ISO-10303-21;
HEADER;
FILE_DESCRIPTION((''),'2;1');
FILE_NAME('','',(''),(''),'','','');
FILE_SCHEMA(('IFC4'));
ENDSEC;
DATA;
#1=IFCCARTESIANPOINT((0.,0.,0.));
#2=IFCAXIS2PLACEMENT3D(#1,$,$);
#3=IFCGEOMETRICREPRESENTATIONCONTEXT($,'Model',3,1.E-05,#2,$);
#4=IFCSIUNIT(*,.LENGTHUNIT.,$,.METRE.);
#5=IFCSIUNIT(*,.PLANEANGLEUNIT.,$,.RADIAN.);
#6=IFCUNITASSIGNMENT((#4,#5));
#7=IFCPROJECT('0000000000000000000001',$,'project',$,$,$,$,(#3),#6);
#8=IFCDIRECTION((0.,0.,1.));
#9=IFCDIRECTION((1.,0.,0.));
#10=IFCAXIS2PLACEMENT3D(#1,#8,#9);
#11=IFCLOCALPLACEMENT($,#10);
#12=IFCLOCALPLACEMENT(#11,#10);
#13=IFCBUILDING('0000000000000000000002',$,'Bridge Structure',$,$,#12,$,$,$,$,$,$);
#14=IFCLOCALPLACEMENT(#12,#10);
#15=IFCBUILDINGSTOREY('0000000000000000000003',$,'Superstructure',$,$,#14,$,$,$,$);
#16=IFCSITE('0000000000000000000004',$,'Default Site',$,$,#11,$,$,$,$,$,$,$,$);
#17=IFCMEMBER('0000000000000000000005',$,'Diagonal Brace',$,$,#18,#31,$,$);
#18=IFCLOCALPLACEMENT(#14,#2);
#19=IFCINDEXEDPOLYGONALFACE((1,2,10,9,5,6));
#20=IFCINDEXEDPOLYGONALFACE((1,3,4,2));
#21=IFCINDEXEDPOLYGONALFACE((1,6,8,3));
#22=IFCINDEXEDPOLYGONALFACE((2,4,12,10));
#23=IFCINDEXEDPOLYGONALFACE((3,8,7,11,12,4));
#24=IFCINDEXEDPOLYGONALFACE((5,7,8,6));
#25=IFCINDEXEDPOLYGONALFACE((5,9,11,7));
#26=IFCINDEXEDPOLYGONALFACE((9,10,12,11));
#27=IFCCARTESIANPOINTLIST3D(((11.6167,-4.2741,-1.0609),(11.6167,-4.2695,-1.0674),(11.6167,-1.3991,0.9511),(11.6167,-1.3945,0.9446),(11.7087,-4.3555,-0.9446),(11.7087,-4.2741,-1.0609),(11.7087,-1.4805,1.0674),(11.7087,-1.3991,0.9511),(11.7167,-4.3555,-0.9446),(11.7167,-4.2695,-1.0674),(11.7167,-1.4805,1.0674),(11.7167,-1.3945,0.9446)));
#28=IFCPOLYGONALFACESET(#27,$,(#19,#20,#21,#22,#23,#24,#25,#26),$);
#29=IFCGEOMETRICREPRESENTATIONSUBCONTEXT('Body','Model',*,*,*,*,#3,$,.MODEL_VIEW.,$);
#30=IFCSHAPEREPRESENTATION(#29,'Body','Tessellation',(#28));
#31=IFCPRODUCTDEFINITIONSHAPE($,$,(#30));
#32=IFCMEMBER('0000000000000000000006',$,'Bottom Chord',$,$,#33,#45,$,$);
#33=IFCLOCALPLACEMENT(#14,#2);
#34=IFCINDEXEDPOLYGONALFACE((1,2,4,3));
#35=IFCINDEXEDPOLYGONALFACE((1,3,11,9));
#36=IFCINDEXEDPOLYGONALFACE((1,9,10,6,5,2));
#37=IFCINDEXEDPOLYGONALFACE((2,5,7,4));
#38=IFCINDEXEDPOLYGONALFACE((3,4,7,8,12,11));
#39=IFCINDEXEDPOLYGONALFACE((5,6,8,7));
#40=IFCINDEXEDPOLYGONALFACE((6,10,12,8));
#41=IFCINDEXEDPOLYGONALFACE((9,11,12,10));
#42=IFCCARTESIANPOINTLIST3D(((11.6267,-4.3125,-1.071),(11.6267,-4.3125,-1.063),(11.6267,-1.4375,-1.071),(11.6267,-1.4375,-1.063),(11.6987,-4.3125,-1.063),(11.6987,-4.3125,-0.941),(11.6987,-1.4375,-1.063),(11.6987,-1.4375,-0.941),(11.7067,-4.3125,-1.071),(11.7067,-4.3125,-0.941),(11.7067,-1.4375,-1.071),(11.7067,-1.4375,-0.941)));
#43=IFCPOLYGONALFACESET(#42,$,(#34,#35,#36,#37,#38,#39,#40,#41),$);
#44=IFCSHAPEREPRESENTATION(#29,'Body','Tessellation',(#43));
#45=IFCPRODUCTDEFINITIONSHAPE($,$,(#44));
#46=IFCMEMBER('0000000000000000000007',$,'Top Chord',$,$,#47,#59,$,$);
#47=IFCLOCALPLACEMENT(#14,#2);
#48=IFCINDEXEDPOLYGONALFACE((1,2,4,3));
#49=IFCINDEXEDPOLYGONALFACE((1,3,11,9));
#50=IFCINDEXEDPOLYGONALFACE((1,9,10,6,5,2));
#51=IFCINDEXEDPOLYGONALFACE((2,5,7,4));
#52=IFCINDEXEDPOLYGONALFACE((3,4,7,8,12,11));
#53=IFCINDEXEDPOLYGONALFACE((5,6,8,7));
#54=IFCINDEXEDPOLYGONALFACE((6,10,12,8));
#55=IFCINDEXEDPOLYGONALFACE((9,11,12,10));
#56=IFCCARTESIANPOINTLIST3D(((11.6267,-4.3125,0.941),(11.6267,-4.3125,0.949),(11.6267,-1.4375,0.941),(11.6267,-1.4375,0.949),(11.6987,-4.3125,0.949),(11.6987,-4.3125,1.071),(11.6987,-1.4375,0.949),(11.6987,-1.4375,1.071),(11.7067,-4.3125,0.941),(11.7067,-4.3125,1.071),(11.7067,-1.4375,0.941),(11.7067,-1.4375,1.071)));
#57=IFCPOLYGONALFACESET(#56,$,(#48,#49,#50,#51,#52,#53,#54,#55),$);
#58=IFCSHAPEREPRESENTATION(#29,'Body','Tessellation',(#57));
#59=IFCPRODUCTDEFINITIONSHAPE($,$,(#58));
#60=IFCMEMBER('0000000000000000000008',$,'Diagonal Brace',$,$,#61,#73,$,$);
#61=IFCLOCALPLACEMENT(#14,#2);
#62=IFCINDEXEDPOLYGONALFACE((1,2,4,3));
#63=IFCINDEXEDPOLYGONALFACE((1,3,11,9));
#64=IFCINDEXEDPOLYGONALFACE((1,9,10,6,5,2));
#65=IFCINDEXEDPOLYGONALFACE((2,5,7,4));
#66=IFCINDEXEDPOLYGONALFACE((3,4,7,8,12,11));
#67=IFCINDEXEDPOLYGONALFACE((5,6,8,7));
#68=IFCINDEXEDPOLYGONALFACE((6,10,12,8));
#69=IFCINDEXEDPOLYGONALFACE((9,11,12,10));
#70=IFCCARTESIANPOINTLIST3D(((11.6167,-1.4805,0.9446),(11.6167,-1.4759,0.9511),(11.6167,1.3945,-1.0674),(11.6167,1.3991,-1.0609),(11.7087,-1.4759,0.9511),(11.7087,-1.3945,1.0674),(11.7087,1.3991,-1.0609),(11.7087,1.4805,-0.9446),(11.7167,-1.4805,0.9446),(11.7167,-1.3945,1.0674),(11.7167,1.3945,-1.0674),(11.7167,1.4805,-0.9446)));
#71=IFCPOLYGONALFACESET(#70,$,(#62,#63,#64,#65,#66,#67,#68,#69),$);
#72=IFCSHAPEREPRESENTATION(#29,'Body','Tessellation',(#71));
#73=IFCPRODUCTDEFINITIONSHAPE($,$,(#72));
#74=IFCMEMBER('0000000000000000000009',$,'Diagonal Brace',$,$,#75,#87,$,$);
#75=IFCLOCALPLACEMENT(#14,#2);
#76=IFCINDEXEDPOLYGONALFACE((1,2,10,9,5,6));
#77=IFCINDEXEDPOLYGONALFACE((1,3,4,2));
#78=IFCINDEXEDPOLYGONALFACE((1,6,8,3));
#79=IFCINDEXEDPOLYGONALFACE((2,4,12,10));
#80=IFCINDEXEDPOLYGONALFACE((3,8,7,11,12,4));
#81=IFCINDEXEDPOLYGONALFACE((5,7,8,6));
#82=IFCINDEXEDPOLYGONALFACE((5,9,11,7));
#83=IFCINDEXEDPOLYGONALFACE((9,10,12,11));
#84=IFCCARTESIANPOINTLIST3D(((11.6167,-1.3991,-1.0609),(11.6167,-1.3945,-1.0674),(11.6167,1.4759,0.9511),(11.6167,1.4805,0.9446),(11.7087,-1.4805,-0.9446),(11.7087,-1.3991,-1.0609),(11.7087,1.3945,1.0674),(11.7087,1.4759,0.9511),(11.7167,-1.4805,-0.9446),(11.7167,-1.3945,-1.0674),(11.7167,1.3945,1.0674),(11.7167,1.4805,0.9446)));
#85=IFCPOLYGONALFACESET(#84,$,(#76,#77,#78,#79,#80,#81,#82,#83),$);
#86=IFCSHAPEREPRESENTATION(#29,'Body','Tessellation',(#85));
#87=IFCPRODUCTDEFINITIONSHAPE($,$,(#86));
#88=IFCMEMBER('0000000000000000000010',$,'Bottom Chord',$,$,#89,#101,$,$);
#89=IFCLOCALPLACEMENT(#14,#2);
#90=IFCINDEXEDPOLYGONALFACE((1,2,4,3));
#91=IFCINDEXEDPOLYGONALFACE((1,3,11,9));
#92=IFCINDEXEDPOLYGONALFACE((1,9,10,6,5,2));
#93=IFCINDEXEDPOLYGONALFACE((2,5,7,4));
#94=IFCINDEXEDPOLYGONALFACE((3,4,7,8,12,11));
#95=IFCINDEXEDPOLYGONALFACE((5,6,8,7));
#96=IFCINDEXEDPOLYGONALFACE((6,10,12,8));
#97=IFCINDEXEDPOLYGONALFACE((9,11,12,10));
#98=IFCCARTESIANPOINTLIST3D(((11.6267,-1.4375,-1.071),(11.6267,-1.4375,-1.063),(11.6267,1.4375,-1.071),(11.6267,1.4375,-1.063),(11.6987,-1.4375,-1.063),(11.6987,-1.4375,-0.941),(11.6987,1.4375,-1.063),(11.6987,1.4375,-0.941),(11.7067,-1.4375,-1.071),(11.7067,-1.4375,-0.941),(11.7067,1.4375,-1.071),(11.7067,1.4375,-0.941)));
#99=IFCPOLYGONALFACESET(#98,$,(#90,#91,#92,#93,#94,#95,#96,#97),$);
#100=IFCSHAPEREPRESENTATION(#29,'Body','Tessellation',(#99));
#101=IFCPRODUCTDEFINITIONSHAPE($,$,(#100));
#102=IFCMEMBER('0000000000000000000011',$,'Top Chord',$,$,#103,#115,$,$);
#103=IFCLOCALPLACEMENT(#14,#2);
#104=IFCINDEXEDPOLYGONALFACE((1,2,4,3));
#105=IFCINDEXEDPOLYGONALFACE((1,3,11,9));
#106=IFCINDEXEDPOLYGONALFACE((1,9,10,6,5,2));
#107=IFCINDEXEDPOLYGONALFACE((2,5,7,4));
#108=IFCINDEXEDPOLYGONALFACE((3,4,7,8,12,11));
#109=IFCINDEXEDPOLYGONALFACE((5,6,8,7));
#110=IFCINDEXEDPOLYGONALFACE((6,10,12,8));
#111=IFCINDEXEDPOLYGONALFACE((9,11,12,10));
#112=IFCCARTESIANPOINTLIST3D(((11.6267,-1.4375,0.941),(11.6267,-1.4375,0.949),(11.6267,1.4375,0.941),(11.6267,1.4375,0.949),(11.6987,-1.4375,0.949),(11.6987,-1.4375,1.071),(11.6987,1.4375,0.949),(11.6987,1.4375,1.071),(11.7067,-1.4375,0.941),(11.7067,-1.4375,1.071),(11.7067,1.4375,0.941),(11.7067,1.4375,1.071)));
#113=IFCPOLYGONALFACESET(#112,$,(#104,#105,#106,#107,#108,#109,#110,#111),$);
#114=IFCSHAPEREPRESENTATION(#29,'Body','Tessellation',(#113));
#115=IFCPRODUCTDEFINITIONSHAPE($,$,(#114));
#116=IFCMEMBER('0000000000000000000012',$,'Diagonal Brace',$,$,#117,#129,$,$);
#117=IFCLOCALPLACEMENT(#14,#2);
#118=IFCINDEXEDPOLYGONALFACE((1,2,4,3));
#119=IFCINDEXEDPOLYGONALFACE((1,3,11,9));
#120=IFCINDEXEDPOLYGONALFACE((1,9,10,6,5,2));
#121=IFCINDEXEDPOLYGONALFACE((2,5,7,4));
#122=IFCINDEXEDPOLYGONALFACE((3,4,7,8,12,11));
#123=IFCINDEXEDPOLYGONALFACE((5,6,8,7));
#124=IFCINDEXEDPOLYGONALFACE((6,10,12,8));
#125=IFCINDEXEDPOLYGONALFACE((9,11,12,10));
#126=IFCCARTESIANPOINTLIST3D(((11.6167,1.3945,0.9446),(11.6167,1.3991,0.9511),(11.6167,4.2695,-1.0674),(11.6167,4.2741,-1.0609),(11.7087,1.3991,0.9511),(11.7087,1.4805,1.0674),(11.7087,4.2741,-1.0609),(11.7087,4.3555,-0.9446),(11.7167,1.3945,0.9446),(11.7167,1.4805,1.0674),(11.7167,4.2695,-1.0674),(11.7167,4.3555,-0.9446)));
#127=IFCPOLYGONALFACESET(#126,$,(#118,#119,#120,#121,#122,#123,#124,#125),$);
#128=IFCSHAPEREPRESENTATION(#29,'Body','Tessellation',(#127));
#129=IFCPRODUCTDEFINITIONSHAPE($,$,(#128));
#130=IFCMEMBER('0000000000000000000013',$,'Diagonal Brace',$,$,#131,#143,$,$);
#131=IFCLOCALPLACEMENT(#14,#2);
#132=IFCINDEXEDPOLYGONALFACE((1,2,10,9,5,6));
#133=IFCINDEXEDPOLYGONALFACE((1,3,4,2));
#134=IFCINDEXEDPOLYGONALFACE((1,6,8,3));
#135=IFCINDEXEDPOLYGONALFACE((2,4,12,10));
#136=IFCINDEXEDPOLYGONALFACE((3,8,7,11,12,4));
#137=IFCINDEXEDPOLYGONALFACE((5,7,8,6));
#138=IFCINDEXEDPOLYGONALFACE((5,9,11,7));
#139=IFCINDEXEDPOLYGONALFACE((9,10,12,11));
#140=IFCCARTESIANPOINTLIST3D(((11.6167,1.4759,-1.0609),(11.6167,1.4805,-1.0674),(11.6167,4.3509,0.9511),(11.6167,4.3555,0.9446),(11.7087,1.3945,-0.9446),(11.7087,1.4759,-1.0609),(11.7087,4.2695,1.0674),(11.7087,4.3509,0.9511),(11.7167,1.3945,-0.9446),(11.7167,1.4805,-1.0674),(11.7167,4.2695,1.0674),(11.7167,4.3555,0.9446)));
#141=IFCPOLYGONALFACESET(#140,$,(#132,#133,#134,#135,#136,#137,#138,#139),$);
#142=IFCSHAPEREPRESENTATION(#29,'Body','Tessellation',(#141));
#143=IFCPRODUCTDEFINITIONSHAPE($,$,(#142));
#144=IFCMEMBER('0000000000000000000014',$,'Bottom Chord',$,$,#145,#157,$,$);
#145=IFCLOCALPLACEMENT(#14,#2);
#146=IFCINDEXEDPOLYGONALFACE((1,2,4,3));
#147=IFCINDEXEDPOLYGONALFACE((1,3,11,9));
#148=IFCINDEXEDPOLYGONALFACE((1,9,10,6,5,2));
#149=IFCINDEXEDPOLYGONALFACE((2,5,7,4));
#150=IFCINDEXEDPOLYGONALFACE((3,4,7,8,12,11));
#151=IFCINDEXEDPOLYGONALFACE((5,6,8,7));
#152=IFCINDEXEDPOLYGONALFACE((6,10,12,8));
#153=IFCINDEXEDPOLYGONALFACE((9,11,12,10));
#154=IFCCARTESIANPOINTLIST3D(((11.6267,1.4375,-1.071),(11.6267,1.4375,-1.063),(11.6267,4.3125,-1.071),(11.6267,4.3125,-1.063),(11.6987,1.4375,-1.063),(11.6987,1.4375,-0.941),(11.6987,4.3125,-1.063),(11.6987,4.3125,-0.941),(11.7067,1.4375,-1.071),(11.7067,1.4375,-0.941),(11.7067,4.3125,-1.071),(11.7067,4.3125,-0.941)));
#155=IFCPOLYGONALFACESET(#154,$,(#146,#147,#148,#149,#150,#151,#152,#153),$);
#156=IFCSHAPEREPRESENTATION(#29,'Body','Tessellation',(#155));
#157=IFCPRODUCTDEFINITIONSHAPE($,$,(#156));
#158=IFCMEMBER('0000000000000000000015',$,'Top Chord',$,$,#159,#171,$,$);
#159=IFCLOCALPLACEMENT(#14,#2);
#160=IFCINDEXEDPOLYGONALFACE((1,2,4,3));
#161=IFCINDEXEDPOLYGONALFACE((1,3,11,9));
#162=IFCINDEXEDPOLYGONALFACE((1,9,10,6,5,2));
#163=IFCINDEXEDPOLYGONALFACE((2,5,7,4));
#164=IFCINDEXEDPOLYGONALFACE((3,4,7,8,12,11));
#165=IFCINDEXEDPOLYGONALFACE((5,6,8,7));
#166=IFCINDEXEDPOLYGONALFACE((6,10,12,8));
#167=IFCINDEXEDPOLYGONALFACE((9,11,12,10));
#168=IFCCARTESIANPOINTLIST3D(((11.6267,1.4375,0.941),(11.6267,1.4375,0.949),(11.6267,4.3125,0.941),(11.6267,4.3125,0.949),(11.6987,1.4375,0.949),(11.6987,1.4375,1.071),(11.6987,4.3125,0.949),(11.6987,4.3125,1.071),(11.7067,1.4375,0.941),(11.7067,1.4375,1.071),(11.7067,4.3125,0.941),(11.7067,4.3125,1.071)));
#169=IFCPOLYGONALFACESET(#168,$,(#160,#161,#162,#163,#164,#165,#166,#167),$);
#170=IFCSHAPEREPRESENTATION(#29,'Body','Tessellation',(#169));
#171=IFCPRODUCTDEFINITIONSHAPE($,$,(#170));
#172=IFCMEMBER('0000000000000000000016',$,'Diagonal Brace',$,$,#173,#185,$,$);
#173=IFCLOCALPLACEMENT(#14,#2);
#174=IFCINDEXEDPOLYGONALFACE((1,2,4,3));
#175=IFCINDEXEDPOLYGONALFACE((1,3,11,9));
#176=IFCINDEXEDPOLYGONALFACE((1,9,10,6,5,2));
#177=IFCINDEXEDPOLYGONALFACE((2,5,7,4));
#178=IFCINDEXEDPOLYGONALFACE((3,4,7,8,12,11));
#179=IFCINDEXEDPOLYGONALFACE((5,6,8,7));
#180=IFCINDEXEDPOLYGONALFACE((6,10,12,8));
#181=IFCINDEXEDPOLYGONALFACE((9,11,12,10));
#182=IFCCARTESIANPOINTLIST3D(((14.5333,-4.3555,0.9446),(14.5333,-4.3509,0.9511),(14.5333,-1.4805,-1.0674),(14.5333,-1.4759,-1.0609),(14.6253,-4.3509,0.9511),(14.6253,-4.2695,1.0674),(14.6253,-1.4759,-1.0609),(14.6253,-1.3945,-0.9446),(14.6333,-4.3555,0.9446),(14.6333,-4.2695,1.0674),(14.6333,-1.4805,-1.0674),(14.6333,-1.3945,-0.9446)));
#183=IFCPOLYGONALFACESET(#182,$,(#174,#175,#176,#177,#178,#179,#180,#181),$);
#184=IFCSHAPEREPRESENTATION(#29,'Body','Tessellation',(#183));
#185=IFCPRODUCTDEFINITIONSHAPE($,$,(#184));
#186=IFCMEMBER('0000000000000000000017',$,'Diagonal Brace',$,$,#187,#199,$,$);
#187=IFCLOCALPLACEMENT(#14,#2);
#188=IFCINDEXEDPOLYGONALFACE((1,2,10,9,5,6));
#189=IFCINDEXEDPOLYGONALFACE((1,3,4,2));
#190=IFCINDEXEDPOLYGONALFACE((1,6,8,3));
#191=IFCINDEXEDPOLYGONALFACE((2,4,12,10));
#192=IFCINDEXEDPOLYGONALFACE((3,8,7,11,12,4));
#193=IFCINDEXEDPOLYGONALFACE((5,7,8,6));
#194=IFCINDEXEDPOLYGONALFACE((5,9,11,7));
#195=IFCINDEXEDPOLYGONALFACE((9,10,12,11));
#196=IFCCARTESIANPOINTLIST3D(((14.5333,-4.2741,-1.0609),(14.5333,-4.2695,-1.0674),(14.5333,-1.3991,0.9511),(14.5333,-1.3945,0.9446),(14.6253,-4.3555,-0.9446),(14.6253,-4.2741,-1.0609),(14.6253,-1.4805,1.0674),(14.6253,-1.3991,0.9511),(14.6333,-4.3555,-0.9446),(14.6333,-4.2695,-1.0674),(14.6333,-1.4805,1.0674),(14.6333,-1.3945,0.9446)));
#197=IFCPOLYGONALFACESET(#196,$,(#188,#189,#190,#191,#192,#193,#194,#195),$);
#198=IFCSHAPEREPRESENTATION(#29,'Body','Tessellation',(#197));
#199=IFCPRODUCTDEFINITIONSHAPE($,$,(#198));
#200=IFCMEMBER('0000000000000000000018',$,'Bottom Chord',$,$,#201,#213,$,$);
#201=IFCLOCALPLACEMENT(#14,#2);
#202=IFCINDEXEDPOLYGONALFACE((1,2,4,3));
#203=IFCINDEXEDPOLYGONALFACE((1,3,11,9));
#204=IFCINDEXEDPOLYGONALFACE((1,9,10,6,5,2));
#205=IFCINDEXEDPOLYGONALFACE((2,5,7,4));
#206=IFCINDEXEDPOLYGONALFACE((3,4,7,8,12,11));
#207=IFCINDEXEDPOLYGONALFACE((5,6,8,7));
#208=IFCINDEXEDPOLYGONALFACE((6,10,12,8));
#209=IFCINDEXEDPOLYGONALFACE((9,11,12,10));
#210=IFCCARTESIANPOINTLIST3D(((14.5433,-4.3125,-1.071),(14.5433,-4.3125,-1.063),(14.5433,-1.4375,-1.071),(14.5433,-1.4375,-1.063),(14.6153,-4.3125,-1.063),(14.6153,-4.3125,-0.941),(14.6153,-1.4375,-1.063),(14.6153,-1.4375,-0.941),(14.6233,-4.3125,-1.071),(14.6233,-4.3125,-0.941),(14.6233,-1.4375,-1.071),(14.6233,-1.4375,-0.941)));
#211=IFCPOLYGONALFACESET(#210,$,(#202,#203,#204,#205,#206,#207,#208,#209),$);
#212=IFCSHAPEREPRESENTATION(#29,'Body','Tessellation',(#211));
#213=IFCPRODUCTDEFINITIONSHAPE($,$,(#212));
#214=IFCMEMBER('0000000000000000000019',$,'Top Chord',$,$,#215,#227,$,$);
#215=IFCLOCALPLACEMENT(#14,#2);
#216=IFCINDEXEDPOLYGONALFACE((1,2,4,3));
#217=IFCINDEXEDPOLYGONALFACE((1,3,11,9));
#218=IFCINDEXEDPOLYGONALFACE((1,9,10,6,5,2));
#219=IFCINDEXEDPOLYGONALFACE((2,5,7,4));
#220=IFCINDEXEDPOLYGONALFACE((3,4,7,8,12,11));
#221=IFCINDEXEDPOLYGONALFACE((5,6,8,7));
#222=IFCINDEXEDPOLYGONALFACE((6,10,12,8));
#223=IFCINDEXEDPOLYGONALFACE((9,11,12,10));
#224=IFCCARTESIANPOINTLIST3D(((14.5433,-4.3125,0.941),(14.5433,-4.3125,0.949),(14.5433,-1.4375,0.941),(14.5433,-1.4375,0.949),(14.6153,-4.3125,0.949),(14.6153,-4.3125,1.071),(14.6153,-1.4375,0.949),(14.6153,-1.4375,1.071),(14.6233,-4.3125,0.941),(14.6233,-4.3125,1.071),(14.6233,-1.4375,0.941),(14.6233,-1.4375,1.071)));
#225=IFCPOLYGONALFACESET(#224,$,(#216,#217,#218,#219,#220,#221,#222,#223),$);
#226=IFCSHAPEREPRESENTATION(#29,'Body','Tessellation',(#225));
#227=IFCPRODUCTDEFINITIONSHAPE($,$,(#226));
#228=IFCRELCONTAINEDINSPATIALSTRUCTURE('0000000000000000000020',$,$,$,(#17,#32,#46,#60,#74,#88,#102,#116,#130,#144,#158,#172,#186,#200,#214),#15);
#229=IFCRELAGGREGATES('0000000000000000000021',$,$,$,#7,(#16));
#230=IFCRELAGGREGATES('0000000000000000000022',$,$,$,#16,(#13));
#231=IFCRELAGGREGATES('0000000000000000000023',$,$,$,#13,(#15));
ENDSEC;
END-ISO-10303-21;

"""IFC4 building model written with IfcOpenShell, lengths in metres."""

from ifc_helpers import new_model, si_unit, frame, origin, origin_with_axes, origin_2d_with_axis, place, context, subcontext, project, spatial, l_section, extrude, element, save


model = new_model("IFC4")

# Units and contexts
model_context = context("Model", 3, precision=1e-05, world=origin())
body_context = subcontext(model_context, "Body", "Model", "MODEL_VIEW")
ifc_project = project(units=[si_unit("LENGTHUNIT", "METRE"), si_unit("PLANEANGLEUNIT", "RADIAN")], contexts=[model_context])

# Site, building, storey
site_placement = place(None, origin_with_axes())
site = spatial("IfcSite", under=ifc_project, at=site_placement, Name="Default Site")
building_placement = place(site_placement, origin_with_axes())
building = spatial("IfcBuilding", under=site, at=building_placement, Name="Bridge Structure")
storey_placement = place(building_placement, origin_with_axes())
storey = spatial("IfcBuildingStorey", under=building, at=storey_placement, Name="Superstructure")

# Members
member_placement = place(storey_placement, frame((11.6667, -4.3125, -1.006), z_axis=(0.0, 0.819299, 0.573367), x_axis=(-1.0, 0.0, 0.0)))
element("IfcMember", 1, at=member_placement, inside=storey, Name="Diagonal Brace", context=body_context, shape_type="SweptSolid", body=[
    extrude(l_section(Depth=0.15, Width=0.1, Thickness=0.008, at=origin_2d_with_axis()), origin_with_axes(), (0.0, 0.0, 1.0), 3.5091),
])
for number, where, z_axis, x_axis, name in (
    (2, (11.6667, -4.3125, -1.006), (0.0, 1.0, 0.0), (-1.0, 0.0, 0.0), "Bottom Chord"),
    (3, (11.6667, -4.3125, 1.006), (0.0, 1.0, 0.0), (-1.0, 0.0, 0.0), "Top Chord"),
):
    element("IfcMember", number, at=place(storey_placement, frame(where, z_axis=z_axis, x_axis=x_axis)), inside=storey, Name=name, context=body_context, shape_type="SweptSolid", body=[
        extrude(l_section(Depth=0.13, Width=0.08, Thickness=0.008, at=origin_2d_with_axis()), origin_with_axes(), (0.0, 0.0, 1.0), 2.875),
    ])
for number, where, z_axis, x_axis, name in (
    (4, (11.6667, -1.4375, 1.006), (0.0, 0.819299, -0.573367), (-1.0, 0.0, 0.0), "Diagonal Brace"),
    (5, (11.6667, -1.4375, -1.006), (0.0, 0.819299, 0.573367), (-1.0, 0.0, 0.0), "Diagonal Brace"),
):
    element("IfcMember", number, at=place(storey_placement, frame(where, z_axis=z_axis, x_axis=x_axis)), inside=storey, Name=name, context=body_context, shape_type="SweptSolid", body=[
        extrude(l_section(Depth=0.15, Width=0.1, Thickness=0.008, at=origin_2d_with_axis()), origin_with_axes(), (0.0, 0.0, 1.0), 3.5091),
    ])
for number, where, z_axis, x_axis, name in (
    (6, (11.6667, -1.4375, -1.006), (0.0, 1.0, 0.0), (-1.0, 0.0, 0.0), "Bottom Chord"),
    (7, (11.6667, -1.4375, 1.006), (0.0, 1.0, 0.0), (-1.0, 0.0, 0.0), "Top Chord"),
):
    element("IfcMember", number, at=place(storey_placement, frame(where, z_axis=z_axis, x_axis=x_axis)), inside=storey, Name=name, context=body_context, shape_type="SweptSolid", body=[
        extrude(l_section(Depth=0.13, Width=0.08, Thickness=0.008, at=origin_2d_with_axis()), origin_with_axes(), (0.0, 0.0, 1.0), 2.875),
    ])
for number, where, z_axis, x_axis, name in (
    (8, (11.6667, 1.4375, 1.006), (0.0, 0.819299, -0.573367), (-1.0, 0.0, 0.0), "Diagonal Brace"),
    (9, (11.6667, 1.4375, -1.006), (0.0, 0.819299, 0.573367), (-1.0, 0.0, 0.0), "Diagonal Brace"),
):
    element("IfcMember", number, at=place(storey_placement, frame(where, z_axis=z_axis, x_axis=x_axis)), inside=storey, Name=name, context=body_context, shape_type="SweptSolid", body=[
        extrude(l_section(Depth=0.15, Width=0.1, Thickness=0.008, at=origin_2d_with_axis()), origin_with_axes(), (0.0, 0.0, 1.0), 3.5091),
    ])
for number, where, z_axis, x_axis, name in (
    (10, (11.6667, 1.4375, -1.006), (0.0, 1.0, 0.0), (-1.0, 0.0, 0.0), "Bottom Chord"),
    (11, (11.6667, 1.4375, 1.006), (0.0, 1.0, 0.0), (-1.0, 0.0, 0.0), "Top Chord"),
):
    element("IfcMember", number, at=place(storey_placement, frame(where, z_axis=z_axis, x_axis=x_axis)), inside=storey, Name=name, context=body_context, shape_type="SweptSolid", body=[
        extrude(l_section(Depth=0.13, Width=0.08, Thickness=0.008, at=origin_2d_with_axis()), origin_with_axes(), (0.0, 0.0, 1.0), 2.875),
    ])
for number, where, z_axis, x_axis, name in (
    (12, (14.5833, -4.3125, 1.006), (0.0, 0.819299, -0.573367), (-1.0, 0.0, 0.0), "Diagonal Brace"),
    (13, (14.5833, -4.3125, -1.006), (0.0, 0.819299, 0.573367), (-1.0, 0.0, 0.0), "Diagonal Brace"),
):
    element("IfcMember", number, at=place(storey_placement, frame(where, z_axis=z_axis, x_axis=x_axis)), inside=storey, Name=name, context=body_context, shape_type="SweptSolid", body=[
        extrude(l_section(Depth=0.15, Width=0.1, Thickness=0.008, at=origin_2d_with_axis()), origin_with_axes(), (0.0, 0.0, 1.0), 3.5091),
    ])
for number, where, z_axis, x_axis, name in (
    (14, (14.5833, -4.3125, -1.006), (0.0, 1.0, 0.0), (-1.0, 0.0, 0.0), "Bottom Chord"),
    (15, (14.5833, -4.3125, 1.006), (0.0, 1.0, 0.0), (-1.0, 0.0, 0.0), "Top Chord"),
):
    element("IfcMember", number, at=place(storey_placement, frame(where, z_axis=z_axis, x_axis=x_axis)), inside=storey, Name=name, context=body_context, shape_type="SweptSolid", body=[
        extrude(l_section(Depth=0.13, Width=0.08, Thickness=0.008, at=origin_2d_with_axis()), origin_with_axes(), (0.0, 0.0, 1.0), 2.875),
    ])

save(model, "model.ifc")
